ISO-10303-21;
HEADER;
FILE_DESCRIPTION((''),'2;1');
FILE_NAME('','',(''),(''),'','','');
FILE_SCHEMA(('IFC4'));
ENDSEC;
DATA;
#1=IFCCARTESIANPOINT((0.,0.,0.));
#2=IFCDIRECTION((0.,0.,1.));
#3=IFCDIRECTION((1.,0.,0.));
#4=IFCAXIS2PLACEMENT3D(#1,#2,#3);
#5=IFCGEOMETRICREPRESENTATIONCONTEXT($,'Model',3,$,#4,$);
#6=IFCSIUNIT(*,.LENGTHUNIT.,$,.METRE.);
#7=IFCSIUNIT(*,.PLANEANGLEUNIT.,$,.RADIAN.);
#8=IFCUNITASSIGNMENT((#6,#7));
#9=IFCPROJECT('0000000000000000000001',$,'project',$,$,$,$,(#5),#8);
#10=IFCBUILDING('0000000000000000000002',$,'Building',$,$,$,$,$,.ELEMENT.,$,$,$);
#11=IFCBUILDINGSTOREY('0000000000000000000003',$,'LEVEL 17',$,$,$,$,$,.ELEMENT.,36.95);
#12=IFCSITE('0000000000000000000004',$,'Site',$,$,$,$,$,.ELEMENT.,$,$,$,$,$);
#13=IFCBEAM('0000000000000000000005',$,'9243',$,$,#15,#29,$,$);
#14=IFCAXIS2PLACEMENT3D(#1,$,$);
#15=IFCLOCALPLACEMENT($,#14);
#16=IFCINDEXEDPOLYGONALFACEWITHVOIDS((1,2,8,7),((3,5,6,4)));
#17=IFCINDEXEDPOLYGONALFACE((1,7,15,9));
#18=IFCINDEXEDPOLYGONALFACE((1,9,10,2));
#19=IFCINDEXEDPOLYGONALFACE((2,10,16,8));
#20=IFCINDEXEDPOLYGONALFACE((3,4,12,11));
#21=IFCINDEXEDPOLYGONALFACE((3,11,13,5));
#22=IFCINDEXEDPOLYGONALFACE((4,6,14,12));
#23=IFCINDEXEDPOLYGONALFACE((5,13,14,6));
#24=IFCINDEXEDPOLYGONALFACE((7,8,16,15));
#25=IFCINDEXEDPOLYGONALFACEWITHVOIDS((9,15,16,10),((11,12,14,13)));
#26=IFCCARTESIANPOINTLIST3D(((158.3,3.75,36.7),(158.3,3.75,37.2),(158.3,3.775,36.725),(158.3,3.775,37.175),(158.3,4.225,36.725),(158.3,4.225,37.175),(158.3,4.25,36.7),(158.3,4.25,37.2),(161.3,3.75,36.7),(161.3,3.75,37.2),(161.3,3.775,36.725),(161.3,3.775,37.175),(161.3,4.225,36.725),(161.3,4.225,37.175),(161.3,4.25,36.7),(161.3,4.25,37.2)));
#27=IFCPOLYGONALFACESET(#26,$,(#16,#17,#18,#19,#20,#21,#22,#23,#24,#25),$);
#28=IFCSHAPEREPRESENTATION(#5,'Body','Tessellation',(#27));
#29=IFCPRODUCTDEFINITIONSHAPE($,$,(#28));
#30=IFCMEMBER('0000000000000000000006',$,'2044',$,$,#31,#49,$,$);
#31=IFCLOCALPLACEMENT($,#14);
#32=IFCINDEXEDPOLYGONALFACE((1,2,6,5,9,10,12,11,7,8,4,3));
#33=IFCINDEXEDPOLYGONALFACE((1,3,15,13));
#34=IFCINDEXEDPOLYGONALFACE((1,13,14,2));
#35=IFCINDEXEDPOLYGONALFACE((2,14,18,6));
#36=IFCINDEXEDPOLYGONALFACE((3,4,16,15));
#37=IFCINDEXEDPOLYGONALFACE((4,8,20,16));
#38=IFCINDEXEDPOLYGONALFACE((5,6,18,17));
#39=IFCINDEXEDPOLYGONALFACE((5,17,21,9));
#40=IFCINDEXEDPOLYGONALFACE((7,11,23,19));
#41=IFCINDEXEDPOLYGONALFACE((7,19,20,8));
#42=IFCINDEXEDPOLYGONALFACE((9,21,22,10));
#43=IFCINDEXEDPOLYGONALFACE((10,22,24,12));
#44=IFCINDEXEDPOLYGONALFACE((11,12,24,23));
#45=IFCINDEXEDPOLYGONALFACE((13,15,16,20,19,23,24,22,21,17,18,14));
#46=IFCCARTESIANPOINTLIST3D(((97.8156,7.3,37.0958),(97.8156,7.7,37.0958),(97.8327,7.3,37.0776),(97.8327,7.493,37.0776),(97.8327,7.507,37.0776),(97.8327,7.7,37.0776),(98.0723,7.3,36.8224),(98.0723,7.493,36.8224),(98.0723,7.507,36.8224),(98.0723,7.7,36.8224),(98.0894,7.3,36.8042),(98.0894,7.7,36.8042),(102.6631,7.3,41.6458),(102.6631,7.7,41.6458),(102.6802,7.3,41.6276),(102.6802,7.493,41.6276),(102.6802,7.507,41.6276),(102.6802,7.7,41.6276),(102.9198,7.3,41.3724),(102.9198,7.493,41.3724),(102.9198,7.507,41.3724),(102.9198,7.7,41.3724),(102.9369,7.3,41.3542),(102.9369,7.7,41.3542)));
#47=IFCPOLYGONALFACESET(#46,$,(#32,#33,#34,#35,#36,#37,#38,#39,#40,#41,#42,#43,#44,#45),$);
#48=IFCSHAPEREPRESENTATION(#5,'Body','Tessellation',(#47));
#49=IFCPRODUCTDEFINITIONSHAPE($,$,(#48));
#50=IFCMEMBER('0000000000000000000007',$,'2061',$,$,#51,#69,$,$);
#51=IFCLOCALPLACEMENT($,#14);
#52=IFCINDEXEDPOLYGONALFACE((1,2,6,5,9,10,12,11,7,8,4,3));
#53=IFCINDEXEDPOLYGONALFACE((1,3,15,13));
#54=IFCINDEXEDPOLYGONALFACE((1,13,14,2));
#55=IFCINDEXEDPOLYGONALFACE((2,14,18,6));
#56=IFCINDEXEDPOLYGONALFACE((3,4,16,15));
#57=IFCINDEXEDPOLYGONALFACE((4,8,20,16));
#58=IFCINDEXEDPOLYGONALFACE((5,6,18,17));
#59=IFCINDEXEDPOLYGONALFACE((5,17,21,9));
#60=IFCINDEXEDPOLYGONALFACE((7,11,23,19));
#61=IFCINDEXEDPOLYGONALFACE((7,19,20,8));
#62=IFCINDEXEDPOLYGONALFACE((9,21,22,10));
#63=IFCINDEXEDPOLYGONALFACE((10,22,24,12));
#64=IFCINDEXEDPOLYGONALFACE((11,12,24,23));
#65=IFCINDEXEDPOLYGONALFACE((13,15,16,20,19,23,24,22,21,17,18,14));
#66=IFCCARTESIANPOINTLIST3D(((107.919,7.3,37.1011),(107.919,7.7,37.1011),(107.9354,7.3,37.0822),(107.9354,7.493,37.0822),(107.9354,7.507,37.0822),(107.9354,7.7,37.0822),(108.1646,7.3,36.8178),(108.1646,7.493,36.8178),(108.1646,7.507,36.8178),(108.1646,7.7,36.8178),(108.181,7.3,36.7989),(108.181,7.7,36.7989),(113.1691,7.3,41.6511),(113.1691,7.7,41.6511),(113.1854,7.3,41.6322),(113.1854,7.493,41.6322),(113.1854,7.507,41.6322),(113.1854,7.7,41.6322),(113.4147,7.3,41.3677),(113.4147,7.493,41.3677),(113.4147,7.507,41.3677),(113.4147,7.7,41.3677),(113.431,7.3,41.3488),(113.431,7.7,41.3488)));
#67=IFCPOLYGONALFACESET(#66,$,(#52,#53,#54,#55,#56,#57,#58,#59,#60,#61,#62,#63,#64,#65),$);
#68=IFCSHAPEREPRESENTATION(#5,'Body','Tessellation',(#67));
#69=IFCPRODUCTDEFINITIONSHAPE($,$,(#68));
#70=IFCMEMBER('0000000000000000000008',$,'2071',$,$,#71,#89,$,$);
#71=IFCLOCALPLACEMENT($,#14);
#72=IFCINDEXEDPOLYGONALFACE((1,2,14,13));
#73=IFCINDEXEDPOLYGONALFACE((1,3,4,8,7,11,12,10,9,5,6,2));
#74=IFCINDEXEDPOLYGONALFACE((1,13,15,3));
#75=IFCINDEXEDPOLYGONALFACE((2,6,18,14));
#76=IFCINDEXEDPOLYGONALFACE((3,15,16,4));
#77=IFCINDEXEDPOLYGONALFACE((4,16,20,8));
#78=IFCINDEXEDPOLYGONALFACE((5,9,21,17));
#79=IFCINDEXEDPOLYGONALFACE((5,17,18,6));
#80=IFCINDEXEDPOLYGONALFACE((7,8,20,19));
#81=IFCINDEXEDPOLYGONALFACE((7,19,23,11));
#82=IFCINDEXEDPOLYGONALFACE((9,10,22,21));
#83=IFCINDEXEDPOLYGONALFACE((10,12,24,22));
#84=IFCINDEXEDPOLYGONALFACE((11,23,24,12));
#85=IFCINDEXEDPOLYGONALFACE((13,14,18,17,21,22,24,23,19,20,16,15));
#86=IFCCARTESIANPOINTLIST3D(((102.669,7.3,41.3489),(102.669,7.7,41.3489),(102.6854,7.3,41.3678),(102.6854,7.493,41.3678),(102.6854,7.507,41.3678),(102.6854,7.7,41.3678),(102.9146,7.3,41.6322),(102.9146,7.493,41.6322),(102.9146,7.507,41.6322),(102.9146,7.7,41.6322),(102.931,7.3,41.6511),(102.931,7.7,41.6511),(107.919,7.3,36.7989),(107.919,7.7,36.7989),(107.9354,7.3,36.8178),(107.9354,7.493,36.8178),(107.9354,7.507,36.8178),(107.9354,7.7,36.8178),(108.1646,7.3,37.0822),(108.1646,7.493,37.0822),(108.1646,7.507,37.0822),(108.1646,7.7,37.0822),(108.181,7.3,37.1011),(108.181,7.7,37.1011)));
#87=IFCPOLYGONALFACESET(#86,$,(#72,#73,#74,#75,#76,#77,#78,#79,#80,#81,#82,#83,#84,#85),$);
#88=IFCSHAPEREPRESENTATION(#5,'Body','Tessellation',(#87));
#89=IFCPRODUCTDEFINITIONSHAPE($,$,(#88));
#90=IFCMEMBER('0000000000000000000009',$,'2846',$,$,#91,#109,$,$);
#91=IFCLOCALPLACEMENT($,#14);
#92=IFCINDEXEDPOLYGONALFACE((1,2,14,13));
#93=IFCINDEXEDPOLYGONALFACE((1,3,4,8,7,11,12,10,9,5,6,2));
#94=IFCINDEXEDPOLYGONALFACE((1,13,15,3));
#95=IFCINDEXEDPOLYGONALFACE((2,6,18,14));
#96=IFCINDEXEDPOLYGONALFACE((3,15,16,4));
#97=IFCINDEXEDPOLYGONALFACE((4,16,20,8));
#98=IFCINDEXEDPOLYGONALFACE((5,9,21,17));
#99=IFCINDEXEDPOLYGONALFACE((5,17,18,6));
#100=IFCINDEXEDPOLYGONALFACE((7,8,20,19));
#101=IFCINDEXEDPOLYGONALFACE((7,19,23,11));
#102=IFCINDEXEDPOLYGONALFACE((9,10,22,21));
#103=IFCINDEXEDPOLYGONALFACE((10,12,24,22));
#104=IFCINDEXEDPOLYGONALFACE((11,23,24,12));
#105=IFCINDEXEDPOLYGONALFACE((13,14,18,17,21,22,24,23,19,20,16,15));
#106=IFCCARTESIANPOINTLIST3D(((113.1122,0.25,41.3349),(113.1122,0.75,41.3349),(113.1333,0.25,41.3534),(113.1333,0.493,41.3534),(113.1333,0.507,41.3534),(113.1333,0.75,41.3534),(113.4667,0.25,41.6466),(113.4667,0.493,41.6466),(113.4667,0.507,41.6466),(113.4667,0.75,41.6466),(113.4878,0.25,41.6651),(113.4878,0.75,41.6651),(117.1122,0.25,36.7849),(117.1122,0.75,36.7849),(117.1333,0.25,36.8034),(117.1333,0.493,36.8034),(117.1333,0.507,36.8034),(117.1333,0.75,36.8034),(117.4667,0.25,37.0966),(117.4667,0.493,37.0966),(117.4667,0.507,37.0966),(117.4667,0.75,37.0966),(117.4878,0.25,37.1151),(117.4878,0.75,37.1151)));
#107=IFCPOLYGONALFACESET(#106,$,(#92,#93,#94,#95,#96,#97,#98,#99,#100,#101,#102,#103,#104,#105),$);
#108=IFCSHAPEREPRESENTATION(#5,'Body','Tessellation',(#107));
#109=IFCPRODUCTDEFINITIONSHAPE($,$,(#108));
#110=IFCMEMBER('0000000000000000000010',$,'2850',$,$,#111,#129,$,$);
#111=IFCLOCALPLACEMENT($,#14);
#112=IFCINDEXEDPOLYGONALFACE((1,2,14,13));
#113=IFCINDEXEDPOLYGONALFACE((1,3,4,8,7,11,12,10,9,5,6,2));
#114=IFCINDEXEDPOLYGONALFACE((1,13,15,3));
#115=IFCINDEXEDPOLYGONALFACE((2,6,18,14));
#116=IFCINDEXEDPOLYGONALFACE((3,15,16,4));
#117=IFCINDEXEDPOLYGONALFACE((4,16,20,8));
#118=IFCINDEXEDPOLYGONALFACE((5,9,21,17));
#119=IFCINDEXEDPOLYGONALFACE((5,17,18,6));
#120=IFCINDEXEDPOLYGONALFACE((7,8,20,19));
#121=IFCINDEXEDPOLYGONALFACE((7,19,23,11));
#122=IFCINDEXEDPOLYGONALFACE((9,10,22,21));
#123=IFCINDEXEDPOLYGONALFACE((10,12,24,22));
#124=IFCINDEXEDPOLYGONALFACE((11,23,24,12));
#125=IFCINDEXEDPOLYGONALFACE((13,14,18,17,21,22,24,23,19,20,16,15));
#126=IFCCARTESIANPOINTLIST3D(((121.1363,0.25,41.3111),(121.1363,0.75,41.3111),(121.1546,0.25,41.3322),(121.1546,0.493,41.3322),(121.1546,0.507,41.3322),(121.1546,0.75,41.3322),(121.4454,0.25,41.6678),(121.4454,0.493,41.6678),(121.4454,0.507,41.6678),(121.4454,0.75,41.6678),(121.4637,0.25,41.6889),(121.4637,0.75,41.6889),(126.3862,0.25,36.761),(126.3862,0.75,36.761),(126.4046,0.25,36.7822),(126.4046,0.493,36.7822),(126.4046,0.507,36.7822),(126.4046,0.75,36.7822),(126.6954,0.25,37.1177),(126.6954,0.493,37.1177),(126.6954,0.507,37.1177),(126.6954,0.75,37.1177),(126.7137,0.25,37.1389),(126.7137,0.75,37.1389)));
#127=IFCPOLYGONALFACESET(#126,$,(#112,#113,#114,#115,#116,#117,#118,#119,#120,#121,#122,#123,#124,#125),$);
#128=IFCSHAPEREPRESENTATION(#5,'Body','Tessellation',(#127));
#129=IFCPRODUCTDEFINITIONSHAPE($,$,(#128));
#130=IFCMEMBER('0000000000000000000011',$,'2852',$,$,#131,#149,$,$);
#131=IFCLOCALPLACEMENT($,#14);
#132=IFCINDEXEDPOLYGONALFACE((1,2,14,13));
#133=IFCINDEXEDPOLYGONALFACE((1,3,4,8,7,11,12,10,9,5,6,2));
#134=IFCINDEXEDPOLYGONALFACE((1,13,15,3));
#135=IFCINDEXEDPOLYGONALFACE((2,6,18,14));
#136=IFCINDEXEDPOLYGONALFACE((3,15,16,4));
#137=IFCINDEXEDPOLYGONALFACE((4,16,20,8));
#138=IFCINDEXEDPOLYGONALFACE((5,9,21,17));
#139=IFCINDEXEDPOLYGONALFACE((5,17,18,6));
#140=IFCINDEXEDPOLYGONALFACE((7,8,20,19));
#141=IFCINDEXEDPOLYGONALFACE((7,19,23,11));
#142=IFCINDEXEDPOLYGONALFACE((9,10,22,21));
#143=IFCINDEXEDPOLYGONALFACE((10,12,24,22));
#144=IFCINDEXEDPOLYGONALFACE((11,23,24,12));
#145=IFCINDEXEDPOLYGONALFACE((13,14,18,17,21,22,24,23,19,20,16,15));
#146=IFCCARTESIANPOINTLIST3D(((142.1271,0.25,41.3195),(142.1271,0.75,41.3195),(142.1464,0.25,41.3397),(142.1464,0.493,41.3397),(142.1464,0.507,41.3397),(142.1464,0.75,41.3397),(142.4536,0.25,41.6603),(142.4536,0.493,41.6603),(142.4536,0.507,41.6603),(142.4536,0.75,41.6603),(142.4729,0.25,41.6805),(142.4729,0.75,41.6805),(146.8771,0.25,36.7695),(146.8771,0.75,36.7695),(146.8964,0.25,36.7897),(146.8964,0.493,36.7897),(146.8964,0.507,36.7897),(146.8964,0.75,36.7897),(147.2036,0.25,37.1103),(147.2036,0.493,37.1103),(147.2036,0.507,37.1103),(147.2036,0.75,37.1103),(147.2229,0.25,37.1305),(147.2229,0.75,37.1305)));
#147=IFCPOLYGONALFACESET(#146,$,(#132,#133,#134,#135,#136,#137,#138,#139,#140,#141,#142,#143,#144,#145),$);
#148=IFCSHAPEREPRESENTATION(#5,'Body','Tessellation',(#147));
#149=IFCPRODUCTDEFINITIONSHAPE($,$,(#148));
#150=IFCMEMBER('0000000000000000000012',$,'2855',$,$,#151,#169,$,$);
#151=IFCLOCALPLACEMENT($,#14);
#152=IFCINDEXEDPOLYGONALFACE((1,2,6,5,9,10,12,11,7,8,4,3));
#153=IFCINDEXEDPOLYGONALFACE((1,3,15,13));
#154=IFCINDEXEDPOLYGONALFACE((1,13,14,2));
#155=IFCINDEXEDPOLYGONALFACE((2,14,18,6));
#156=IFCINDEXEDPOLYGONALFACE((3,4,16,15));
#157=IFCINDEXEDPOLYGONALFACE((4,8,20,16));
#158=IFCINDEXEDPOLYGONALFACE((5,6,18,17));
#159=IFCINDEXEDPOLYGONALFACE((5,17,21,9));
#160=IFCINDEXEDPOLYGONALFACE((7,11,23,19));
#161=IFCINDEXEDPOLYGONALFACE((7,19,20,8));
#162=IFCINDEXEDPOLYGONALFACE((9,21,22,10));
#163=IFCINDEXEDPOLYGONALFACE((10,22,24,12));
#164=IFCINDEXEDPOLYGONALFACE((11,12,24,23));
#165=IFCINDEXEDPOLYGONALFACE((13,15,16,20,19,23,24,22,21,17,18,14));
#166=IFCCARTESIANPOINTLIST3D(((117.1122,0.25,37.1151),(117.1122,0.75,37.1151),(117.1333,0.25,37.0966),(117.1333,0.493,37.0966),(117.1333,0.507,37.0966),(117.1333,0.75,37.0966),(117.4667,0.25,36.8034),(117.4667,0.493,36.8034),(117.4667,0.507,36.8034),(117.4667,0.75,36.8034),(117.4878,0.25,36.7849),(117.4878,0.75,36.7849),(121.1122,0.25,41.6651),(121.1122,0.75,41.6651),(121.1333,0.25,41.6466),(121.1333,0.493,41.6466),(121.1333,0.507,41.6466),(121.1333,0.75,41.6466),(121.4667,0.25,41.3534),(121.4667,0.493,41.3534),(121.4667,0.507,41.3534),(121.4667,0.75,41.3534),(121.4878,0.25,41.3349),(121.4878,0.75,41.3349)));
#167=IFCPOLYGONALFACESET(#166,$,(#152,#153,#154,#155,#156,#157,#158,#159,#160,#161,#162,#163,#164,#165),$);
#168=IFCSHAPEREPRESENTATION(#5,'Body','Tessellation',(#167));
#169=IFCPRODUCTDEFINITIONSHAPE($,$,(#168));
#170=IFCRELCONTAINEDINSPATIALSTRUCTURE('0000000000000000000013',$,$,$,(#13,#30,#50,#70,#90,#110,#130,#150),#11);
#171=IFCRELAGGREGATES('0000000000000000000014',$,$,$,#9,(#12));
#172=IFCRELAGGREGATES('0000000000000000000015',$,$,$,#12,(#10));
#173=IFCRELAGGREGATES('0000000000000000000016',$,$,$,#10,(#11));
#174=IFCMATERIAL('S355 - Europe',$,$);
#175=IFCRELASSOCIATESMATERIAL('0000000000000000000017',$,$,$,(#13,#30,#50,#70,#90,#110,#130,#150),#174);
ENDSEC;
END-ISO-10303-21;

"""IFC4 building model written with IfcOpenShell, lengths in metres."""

from ifc_helpers import new_model, si_unit, frame, origin_with_axes, origin_2d_with_axis, place, context, project, spatial, hollow_rectangle, i_section, extrude, material, material_profile, profile_set, profile_usage, element, save


model = new_model("IFC4")

# Units and contexts
model_context = context("Model", 3, world=origin_with_axes())
ifc_project = project(units=[si_unit("LENGTHUNIT", "METRE"), si_unit("PLANEANGLEUNIT", "RADIAN")], contexts=[model_context])

# Site, building, storey
site = spatial("IfcSite", under=ifc_project, Name="Site", CompositionType="ELEMENT")
building = spatial("IfcBuilding", under=site, Name="Building", CompositionType="ELEMENT")
storey = spatial("IfcBuildingStorey", under=building, Name="LEVEL 17", CompositionType="ELEMENT", Elevation=36.95)

# Shared definitions
ifc_material = material(Name="S355 - Europe")

# Beam
ifc_material_profile_1 = material_profile(ifc_material, hollow_rectangle(XDim=0.5, YDim=0.5, WallThickness=0.025, at=origin_2d_with_axis()))
ifc_profile_set_1 = profile_set([ifc_material_profile_1])
ifc_profile_usage_1 = profile_usage(ifc_profile_set_1, cardinal=10)
beam_1_placement = place(None, frame((158.3, 4.0, 36.95), z_axis=(1.0, 0.0, 0.0), x_axis=(0.0, 1.0, 0.0)))
element("IfcBeam", 1, at=beam_1_placement, inside=storey, material=ifc_profile_usage_1, Name="9243", context=model_context, shape_type="SweptSolid", body=[
    extrude(hollow_rectangle(XDim=0.5, YDim=0.5, WallThickness=0.025, at=origin_2d_with_axis()), origin_with_axes(), (0.0, 0.0, 1.0), 3.0),
])

# Members
ifc_material_profile_2 = material_profile(ifc_material, i_section(OverallWidth=0.4, OverallDepth=0.4, WebThickness=0.014, FlangeThickness=0.025, at=origin_2d_with_axis()))
ifc_profile_set_2 = profile_set([ifc_material_profile_2])
ifc_profile_usage_2 = profile_usage(ifc_profile_set_2, cardinal=10)
member_1_placement = place(None, frame((102.8, 7.5, 41.5), z_axis=(-0.729127, 0.0, -0.684379), x_axis=(0.0, -1.0, 0.0)))
element("IfcMember", 2, at=member_1_placement, inside=storey, material=ifc_profile_usage_2, Name="2044", context=model_context, shape_type="SweptSolid", body=[
    extrude(i_section(OverallWidth=0.4, OverallDepth=0.4, WebThickness=0.014, FlangeThickness=0.025, at=origin_2d_with_axis()), origin_with_axes(), (0.0, 0.0, 1.0), 6.6484),
])
ifc_material_profile_3 = material_profile(ifc_material, i_section(OverallWidth=0.4, OverallDepth=0.4, WebThickness=0.014, FlangeThickness=0.025, at=origin_2d_with_axis()))
ifc_profile_set_3 = profile_set([ifc_material_profile_3])
ifc_profile_usage_3 = profile_usage(ifc_profile_set_3, cardinal=10)
member_2_placement = place(None, frame((108.05, 7.5, 36.95), z_axis=(0.755695, 0.0, 0.654923), x_axis=(0.0, 1.0, 0.0)))
element("IfcMember", 3, at=member_2_placement, inside=storey, material=ifc_profile_usage_3, Name="2061", context=model_context, shape_type="SweptSolid", body=[
    extrude(i_section(OverallWidth=0.4, OverallDepth=0.4, WebThickness=0.014, FlangeThickness=0.025, at=origin_2d_with_axis()), origin_with_axes(), (0.0, 0.0, 1.0), 6.9473),
])
ifc_material_profile_4 = material_profile(ifc_material, i_section(OverallWidth=0.4, OverallDepth=0.4, WebThickness=0.014, FlangeThickness=0.025, at=origin_2d_with_axis()))
ifc_profile_set_4 = profile_set([ifc_material_profile_4])
ifc_profile_usage_4 = profile_usage(ifc_profile_set_4, cardinal=10)
member_3_placement = place(None, frame((108.05, 7.5, 36.95), z_axis=(-0.755689, 0.0, 0.654931), x_axis=(0.0, -1.0, 0.0)))
element("IfcMember", 4, at=member_3_placement, inside=storey, material=ifc_profile_usage_4, Name="2071", context=model_context, shape_type="SweptSolid", body=[
    extrude(i_section(OverallWidth=0.4, OverallDepth=0.4, WebThickness=0.014, FlangeThickness=0.025, at=origin_2d_with_axis()), origin_with_axes(), (0.0, 0.0, 1.0), 6.9473),
])
ifc_material_profile_5 = material_profile(ifc_material, i_section(OverallWidth=0.5, OverallDepth=0.5, WebThickness=0.014, FlangeThickness=0.028, at=origin_2d_with_axis()))
ifc_profile_set_5 = profile_set([ifc_material_profile_5])
ifc_profile_usage_5 = profile_usage(ifc_profile_set_5, cardinal=10)
member_4_placement = place(None, frame((113.3, 0.5, 41.5), z_axis=(0.660256, 0.0, -0.751041), x_axis=(0.0, 1.0, 0.0)))
element("IfcMember", 5, at=member_4_placement, inside=storey, material=ifc_profile_usage_5, Name="2846", context=model_context, shape_type="SweptSolid", body=[
    extrude(i_section(OverallWidth=0.5, OverallDepth=0.5, WebThickness=0.014, FlangeThickness=0.028, at=origin_2d_with_axis()), origin_with_axes(), (0.0, 0.0, 1.0), 6.0583),
])
ifc_material_profile_6 = material_profile(ifc_material, i_section(OverallWidth=0.5, OverallDepth=0.5, WebThickness=0.014, FlangeThickness=0.028, at=origin_2d_with_axis()))
ifc_profile_set_6 = profile_set([ifc_material_profile_6])
ifc_profile_usage_6 = profile_usage(ifc_profile_set_6, cardinal=10)
member_5_placement = place(None, frame((121.3, 0.5, 41.5), z_axis=(0.755683, 0.0, -0.654938), x_axis=(0.0, 1.0, 0.0)))
element("IfcMember", 6, at=member_5_placement, inside=storey, material=ifc_profile_usage_6, Name="2850", context=model_context, shape_type="SweptSolid", body=[
    extrude(i_section(OverallWidth=0.5, OverallDepth=0.5, WebThickness=0.014, FlangeThickness=0.028, at=origin_2d_with_axis()), origin_with_axes(), (0.0, 0.0, 1.0), 6.9473),
])
ifc_material_profile_7 = material_profile(ifc_material, i_section(OverallWidth=0.5, OverallDepth=0.5, WebThickness=0.014, FlangeThickness=0.028, at=origin_2d_with_axis()))
ifc_profile_set_7 = profile_set([ifc_material_profile_7])
ifc_profile_usage_7 = profile_usage(ifc_profile_set_7, cardinal=10)
member_6_placement = place(None, frame((142.3, 0.5, 41.5), z_axis=(0.722146, 0.0, -0.69174), x_axis=(0.0, 1.0, 0.0)))
element("IfcMember", 7, at=member_6_placement, inside=storey, material=ifc_profile_usage_7, Name="2852", context=model_context, shape_type="SweptSolid", body=[
    extrude(i_section(OverallWidth=0.5, OverallDepth=0.5, WebThickness=0.014, FlangeThickness=0.028, at=origin_2d_with_axis()), origin_with_axes(), (0.0, 0.0, 1.0), 6.5776),
])
ifc_material_profile_8 = material_profile(ifc_material, i_section(OverallWidth=0.5, OverallDepth=0.5, WebThickness=0.014, FlangeThickness=0.028, at=origin_2d_with_axis()))
ifc_profile_set_8 = profile_set([ifc_material_profile_8])
ifc_profile_usage_8 = profile_usage(ifc_profile_set_8, cardinal=10)
member_7_placement = place(None, frame((117.3, 0.5, 36.95), z_axis=(0.660256, 0.0, 0.751041), x_axis=(0.0, 1.0, 0.0)))
element("IfcMember", 8, at=member_7_placement, inside=storey, material=ifc_profile_usage_8, Name="2855", context=model_context, shape_type="SweptSolid", body=[
    extrude(i_section(OverallWidth=0.5, OverallDepth=0.5, WebThickness=0.014, FlangeThickness=0.028, at=origin_2d_with_axis()), origin_with_axes(), (0.0, 0.0, 1.0), 6.0583),
])

save(model, "model.ifc")
